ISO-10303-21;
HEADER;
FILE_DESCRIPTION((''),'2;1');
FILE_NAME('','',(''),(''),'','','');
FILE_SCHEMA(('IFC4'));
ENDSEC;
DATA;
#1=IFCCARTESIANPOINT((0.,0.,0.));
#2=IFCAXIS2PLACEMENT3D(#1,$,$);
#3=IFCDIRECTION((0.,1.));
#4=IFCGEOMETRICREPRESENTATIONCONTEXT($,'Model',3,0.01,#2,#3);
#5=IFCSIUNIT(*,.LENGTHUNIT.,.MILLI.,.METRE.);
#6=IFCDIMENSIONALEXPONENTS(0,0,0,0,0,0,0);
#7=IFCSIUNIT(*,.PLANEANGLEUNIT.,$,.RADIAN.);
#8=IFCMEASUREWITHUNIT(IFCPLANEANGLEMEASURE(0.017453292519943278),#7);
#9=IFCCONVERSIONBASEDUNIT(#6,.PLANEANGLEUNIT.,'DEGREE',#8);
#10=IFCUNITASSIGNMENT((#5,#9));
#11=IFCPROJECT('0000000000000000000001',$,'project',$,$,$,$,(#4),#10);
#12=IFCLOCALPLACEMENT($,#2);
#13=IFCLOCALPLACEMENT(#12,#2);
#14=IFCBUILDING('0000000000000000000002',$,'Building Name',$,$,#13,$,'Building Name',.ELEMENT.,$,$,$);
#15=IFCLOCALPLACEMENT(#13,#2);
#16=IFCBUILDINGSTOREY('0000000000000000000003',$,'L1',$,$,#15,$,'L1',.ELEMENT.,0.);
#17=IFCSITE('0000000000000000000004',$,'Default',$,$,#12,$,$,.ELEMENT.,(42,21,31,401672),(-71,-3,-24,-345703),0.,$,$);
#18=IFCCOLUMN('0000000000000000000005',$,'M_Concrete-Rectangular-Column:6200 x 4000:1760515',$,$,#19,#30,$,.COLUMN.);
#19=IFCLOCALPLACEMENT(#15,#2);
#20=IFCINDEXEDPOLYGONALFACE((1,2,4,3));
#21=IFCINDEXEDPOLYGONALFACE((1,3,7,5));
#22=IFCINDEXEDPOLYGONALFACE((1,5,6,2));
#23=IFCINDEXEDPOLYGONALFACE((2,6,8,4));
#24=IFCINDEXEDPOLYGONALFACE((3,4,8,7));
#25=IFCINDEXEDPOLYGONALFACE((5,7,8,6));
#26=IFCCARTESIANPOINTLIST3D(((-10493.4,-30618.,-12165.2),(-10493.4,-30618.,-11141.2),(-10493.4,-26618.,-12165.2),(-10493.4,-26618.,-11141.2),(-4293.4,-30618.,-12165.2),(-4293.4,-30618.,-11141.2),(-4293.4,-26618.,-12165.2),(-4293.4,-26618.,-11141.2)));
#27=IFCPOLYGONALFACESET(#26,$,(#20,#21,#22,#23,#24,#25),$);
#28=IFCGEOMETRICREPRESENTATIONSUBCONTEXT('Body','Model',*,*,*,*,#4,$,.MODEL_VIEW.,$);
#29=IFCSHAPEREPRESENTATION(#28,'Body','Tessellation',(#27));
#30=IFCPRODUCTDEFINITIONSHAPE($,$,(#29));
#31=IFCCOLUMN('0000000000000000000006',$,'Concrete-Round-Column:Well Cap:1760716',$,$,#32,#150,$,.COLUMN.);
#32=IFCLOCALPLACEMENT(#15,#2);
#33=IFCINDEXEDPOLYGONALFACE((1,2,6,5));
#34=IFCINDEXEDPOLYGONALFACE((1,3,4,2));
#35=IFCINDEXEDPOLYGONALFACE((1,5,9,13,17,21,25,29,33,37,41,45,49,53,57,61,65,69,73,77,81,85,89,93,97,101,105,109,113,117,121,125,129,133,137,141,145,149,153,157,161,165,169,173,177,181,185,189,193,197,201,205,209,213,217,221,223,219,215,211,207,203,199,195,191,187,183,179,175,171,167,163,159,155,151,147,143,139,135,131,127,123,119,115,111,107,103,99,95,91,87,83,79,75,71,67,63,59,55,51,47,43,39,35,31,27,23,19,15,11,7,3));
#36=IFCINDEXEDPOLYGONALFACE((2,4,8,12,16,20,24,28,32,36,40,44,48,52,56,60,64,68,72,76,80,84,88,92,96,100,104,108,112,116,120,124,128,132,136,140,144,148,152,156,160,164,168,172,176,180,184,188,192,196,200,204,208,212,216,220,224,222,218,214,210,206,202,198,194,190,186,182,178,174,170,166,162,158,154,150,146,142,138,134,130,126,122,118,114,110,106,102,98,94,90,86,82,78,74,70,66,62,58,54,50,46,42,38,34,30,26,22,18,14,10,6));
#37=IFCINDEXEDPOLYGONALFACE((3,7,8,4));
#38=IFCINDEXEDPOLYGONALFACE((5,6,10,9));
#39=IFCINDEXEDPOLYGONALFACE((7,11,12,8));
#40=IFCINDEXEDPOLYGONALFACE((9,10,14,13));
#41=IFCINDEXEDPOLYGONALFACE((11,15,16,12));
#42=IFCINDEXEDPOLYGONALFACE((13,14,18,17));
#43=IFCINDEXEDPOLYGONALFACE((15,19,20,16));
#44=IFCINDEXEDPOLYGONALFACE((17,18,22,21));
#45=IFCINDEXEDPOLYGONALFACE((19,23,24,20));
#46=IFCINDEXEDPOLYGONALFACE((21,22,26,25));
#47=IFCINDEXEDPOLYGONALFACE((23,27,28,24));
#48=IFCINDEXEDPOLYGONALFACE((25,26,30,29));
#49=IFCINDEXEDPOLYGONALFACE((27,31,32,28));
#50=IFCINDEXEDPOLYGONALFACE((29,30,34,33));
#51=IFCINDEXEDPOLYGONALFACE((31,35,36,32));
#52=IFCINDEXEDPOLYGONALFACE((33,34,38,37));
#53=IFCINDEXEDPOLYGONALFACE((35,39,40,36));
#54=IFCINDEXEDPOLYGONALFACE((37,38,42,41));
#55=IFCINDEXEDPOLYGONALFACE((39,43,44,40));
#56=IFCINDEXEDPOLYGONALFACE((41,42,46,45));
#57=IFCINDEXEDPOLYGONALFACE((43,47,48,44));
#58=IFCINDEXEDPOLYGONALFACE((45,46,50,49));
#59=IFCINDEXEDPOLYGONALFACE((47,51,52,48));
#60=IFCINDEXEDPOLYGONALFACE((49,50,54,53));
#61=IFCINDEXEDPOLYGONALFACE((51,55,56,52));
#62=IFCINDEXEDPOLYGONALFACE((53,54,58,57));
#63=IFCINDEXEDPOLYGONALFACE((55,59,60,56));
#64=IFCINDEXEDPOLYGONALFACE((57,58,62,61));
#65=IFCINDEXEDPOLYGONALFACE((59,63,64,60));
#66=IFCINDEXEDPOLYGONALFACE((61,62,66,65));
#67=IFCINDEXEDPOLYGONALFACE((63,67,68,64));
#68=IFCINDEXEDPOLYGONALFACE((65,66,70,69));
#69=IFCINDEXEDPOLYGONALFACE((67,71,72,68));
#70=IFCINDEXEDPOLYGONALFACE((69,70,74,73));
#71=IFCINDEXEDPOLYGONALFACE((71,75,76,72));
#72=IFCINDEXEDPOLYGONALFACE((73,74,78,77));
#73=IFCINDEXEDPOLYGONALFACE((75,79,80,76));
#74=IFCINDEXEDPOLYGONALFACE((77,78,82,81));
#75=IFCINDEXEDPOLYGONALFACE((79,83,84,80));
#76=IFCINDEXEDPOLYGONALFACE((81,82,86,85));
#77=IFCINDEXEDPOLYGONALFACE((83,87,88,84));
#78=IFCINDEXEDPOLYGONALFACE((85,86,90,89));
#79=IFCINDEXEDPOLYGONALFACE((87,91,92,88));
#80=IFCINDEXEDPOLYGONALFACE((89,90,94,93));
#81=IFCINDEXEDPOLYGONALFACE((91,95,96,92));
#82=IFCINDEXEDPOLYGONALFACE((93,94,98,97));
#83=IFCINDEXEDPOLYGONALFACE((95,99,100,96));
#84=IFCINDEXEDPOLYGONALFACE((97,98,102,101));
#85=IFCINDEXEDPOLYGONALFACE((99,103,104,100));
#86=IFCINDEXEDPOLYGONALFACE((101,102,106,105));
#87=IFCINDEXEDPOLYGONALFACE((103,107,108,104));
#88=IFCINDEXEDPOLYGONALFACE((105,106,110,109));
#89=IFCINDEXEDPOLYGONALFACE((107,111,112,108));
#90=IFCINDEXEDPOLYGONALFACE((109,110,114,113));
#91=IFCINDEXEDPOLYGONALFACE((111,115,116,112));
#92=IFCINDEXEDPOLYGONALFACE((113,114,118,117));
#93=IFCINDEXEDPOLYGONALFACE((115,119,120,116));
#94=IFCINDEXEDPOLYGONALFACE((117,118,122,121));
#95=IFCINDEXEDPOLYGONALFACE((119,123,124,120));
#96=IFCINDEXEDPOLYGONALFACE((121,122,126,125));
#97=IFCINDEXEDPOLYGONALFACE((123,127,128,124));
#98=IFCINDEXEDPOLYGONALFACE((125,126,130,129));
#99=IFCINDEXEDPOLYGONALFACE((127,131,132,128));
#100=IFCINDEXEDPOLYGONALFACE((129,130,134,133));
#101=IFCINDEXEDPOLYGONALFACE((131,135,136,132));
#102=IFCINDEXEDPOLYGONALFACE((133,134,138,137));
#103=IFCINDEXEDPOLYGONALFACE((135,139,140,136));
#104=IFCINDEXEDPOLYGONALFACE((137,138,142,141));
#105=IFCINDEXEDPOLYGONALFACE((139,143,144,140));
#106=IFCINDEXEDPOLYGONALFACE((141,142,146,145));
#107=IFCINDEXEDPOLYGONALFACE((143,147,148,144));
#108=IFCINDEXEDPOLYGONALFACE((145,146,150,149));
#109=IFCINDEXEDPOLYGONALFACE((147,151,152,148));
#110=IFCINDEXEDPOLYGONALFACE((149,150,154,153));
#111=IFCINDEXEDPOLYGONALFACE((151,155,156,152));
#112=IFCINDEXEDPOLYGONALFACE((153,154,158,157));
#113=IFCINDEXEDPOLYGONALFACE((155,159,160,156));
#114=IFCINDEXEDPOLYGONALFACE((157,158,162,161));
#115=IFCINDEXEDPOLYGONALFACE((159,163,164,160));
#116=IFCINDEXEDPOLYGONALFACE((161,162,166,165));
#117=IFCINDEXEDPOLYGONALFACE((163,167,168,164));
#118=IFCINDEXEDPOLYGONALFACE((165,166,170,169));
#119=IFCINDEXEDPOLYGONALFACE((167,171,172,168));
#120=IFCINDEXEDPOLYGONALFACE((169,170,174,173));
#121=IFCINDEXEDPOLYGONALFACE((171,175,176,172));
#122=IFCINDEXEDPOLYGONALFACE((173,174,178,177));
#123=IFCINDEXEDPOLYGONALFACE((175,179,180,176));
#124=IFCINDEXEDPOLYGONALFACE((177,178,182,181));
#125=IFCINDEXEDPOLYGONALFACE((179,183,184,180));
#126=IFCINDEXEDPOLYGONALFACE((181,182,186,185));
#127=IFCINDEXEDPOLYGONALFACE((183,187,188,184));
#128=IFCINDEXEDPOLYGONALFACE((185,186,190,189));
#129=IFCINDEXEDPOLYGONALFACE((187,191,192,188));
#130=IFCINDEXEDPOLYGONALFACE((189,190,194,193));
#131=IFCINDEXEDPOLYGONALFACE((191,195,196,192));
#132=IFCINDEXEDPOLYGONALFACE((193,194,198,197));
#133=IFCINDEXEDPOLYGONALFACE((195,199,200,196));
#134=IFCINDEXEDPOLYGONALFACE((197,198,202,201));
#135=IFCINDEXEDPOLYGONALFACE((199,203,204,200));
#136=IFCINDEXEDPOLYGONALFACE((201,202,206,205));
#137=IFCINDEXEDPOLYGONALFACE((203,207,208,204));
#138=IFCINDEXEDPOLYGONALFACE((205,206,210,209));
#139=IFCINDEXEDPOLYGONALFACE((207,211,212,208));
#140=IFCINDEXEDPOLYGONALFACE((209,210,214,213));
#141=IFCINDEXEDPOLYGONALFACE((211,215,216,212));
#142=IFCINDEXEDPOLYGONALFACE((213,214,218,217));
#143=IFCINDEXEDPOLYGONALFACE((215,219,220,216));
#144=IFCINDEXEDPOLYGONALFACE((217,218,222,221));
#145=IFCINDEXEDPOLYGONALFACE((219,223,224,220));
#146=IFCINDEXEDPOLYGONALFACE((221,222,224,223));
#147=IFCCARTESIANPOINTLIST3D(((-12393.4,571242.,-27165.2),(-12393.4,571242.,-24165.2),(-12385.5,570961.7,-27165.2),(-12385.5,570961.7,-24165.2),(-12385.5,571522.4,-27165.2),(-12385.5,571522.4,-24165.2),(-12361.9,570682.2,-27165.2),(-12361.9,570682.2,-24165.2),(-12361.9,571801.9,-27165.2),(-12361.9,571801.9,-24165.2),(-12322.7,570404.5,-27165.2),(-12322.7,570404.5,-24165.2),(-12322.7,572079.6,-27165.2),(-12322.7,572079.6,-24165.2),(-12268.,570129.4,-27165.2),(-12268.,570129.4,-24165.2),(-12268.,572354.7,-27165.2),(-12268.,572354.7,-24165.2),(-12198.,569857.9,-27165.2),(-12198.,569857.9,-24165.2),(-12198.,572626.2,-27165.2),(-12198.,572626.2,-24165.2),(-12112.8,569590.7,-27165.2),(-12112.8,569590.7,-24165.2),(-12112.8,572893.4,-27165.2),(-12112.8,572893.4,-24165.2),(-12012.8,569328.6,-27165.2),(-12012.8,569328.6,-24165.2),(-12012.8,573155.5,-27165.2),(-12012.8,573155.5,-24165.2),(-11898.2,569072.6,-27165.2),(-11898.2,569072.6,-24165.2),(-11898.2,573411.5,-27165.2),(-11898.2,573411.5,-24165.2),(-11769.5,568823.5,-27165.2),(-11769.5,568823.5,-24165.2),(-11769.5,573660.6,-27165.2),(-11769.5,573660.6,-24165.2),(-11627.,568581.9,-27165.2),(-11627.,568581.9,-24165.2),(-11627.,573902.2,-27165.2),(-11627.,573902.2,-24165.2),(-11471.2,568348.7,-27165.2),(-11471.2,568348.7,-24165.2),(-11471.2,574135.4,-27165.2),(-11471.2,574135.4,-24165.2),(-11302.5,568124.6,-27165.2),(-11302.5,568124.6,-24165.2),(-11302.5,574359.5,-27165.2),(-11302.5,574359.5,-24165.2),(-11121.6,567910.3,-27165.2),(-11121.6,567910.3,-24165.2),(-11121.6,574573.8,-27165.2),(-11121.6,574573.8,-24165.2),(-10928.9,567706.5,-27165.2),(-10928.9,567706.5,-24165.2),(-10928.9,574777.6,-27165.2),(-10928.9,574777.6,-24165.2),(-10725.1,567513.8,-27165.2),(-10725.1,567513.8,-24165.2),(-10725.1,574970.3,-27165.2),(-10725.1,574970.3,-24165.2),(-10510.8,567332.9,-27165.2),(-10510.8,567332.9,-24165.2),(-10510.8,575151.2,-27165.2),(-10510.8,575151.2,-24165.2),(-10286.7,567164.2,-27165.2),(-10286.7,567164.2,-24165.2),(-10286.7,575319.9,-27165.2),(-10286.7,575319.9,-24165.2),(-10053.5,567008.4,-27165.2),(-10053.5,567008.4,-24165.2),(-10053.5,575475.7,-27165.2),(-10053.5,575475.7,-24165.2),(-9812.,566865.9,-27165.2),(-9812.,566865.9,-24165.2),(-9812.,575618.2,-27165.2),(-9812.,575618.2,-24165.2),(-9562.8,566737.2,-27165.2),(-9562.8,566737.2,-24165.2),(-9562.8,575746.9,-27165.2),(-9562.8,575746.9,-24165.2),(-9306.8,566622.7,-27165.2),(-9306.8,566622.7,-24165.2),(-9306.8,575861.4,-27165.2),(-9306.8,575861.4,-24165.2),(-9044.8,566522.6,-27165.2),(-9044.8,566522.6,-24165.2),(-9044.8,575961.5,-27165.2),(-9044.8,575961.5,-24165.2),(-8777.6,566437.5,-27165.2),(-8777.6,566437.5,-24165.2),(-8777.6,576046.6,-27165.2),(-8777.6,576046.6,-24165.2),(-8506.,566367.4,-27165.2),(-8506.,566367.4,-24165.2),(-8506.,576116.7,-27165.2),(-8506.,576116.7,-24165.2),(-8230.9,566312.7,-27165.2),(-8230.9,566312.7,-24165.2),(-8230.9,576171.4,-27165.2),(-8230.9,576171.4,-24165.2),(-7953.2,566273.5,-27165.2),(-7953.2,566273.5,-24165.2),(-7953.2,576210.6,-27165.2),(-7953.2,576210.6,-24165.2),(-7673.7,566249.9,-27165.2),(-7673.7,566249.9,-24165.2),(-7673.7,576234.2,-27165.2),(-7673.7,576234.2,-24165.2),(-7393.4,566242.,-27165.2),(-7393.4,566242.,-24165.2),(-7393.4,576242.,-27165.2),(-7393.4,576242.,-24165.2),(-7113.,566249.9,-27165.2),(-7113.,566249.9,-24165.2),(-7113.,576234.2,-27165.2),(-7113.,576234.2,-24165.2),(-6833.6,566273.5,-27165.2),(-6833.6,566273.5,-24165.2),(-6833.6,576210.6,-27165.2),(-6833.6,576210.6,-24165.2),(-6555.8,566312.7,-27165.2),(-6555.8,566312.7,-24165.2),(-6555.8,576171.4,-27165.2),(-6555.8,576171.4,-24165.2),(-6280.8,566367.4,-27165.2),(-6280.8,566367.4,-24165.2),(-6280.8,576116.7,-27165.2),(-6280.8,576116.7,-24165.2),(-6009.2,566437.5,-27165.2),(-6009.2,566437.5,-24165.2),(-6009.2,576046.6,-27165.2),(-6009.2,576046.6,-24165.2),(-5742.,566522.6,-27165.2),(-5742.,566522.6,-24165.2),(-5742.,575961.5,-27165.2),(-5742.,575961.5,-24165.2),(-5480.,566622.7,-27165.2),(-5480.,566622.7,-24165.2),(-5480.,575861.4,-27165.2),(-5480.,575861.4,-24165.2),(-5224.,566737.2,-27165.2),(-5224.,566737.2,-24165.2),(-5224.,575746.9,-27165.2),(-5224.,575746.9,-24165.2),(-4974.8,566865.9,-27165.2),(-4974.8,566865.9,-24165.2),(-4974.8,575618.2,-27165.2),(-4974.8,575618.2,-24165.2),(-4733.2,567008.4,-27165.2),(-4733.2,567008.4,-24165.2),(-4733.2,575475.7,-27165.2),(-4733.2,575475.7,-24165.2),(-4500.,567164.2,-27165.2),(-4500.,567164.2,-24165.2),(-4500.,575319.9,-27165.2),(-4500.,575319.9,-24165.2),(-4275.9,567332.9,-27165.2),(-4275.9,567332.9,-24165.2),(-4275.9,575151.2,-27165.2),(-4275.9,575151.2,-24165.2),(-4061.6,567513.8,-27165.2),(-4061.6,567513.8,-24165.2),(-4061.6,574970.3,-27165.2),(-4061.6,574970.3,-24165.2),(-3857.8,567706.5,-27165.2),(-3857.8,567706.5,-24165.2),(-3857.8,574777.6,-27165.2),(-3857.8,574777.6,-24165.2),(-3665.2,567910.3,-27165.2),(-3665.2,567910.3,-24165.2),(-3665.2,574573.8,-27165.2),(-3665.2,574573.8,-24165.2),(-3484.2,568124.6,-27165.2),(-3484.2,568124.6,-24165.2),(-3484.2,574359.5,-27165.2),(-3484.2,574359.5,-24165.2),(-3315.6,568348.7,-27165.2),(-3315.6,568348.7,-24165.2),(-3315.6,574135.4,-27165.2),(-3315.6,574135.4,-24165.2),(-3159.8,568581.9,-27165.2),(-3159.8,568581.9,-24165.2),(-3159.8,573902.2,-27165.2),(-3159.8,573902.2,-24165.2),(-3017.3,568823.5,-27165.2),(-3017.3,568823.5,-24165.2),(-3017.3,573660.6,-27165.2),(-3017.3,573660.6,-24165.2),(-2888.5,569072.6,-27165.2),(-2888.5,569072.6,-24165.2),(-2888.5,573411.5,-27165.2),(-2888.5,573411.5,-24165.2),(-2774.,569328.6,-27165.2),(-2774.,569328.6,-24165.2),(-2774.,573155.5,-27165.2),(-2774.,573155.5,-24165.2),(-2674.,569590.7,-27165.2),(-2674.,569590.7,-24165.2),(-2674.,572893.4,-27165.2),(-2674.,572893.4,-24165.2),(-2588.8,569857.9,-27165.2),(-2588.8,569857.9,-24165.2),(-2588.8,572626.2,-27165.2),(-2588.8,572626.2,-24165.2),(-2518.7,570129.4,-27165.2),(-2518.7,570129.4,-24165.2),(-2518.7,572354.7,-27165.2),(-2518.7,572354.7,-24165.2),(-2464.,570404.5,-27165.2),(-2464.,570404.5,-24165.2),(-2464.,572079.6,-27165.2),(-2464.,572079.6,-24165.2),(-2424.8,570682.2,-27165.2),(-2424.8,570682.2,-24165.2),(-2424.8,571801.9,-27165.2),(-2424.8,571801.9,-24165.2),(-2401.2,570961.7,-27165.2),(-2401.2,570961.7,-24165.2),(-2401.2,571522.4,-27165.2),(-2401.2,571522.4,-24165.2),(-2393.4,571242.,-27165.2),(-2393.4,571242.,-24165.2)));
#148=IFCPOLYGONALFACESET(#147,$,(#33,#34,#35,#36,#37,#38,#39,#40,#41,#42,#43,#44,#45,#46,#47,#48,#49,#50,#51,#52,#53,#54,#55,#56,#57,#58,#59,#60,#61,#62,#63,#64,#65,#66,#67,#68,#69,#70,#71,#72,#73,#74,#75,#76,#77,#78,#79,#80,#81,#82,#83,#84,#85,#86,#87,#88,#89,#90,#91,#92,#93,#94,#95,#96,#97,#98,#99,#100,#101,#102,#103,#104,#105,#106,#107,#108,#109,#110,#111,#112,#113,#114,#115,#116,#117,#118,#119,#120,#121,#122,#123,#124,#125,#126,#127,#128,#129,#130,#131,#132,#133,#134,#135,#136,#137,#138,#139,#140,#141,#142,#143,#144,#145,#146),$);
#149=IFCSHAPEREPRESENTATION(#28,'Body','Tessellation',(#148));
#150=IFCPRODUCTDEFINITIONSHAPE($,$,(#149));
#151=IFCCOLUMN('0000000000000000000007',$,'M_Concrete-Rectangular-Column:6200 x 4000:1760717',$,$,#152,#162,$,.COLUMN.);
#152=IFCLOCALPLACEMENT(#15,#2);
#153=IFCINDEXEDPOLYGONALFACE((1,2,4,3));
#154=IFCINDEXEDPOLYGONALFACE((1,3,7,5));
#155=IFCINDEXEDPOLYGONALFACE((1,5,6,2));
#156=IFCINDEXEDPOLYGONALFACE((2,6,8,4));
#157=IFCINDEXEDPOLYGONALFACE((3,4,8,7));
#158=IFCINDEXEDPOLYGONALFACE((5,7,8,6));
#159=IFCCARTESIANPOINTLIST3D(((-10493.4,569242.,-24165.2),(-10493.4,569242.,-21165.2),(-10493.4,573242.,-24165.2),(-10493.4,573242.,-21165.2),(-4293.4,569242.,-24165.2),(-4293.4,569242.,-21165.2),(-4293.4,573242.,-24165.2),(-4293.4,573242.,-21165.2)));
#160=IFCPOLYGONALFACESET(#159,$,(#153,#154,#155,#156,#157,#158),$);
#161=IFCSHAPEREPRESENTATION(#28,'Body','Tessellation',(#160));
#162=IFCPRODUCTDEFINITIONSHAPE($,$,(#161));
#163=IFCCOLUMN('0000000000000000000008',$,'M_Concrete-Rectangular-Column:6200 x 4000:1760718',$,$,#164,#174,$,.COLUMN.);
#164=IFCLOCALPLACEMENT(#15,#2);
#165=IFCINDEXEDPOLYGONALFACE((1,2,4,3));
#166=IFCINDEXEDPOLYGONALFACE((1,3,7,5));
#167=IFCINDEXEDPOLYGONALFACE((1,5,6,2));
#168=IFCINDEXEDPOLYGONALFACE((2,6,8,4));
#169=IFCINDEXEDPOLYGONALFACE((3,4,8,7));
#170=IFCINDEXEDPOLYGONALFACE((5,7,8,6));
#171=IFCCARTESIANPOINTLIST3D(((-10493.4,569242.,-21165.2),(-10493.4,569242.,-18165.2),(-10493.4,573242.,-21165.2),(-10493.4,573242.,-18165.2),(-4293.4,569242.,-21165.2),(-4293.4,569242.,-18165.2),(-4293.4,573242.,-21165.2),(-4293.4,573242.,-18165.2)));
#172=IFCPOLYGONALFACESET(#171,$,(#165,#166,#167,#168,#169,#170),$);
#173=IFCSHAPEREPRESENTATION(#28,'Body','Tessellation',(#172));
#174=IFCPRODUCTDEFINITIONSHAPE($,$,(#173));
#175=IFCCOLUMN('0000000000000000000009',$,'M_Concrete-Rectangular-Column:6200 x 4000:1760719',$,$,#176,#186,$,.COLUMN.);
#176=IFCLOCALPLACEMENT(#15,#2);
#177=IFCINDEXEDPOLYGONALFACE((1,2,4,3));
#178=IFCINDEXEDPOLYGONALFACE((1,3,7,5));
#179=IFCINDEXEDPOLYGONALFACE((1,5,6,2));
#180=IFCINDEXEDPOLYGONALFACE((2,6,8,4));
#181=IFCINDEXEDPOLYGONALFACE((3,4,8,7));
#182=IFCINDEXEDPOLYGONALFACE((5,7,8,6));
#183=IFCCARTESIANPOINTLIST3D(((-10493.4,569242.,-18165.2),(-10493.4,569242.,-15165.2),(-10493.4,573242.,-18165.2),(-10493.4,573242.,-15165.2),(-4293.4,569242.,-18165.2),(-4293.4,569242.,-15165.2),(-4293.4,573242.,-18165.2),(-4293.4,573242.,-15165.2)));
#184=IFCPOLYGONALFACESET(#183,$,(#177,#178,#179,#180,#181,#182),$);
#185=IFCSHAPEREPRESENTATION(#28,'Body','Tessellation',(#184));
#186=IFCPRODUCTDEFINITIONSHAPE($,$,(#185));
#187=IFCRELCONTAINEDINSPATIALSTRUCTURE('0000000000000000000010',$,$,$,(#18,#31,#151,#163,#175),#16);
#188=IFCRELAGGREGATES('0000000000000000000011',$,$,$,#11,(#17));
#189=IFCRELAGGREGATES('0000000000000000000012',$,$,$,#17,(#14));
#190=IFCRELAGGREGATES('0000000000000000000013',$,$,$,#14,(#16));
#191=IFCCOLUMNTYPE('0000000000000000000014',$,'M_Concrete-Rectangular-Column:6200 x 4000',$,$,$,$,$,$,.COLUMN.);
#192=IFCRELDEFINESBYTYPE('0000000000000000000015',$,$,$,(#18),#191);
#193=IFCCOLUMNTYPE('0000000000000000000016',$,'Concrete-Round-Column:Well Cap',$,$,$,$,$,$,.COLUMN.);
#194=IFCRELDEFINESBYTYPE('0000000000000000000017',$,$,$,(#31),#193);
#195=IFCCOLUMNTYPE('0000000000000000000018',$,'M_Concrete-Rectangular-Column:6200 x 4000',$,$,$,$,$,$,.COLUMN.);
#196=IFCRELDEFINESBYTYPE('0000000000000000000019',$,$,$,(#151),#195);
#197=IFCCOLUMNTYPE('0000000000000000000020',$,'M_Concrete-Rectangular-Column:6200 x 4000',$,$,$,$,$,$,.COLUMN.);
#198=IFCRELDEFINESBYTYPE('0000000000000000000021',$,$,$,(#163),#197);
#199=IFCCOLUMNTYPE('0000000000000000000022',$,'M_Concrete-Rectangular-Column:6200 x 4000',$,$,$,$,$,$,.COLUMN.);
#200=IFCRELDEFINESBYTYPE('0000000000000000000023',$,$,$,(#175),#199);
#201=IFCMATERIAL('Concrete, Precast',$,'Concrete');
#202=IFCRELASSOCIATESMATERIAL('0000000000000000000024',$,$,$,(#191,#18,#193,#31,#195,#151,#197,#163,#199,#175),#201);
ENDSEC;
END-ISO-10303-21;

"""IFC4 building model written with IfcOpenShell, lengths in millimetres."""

from ifc_helpers import new_model, entity, si_unit, converted_unit, direction, frame, origin, place, context, subcontext, project, spatial, arc, indexed_curve, outline, extrude, source, transform, mapped, material, type_object, type_shapes, element, save


model = new_model("IFC4")

# Units and contexts
model_context = context("Model", 3, precision=0.01, world=origin(), true_north=direction((0.0, 1.0)))
body_context = subcontext(model_context, "Body", "Model", "MODEL_VIEW")
ifc_project = project(units=[si_unit("LENGTHUNIT", "METRE", prefix="MILLI"), converted_unit("PLANEANGLEUNIT", "DEGREE", entity("IfcPlaneAngleMeasure", 0.017453292519943278), si_unit("PLANEANGLEUNIT", "RADIAN"), dimensions=[0, 0, 0, 0, 0, 0, 0])], contexts=[model_context])

# Site, building, storey
site_placement = place(None, origin())
site = spatial("IfcSite", under=ifc_project, at=site_placement, Name="Default", CompositionType="ELEMENT", RefLatitude=(42, 21, 31, 401672), RefLongitude=(-71, -3, -24, -345703), RefElevation=0.0)
building_placement = place(site_placement, origin())
building = spatial("IfcBuilding", under=site, at=building_placement, Name="Building Name", LongName="Building Name", CompositionType="ELEMENT")
storey_placement = place(building_placement, origin())
storey = spatial("IfcBuildingStorey", under=building, at=storey_placement, Name="L1", LongName="L1", CompositionType="ELEMENT", Elevation=0.0)

# Columns
ifc_material_1 = material(Name="Concrete, Precast", Category="Concrete")
column_type_1 = type_object("IfcColumnType", Name="M_Concrete-Rectangular-Column:6200 x 4000", PredefinedType="COLUMN", material=ifc_material_1)
shared_shape_1 = source(origin(), body_context, "Body", "SweptSolid", [
    extrude(outline(indexed_curve([(-2000.0, -3100.0), (2000.0, -3100.0), (2000.0, 3100.0), (-2000.0, 3100.0), (-2000.0, -3100.0)], self_intersect=False)), frame((-7393.4, -28618.0, -12165.2), z_axis=(0.0, 0.0, 1.0), x_axis=(0.0, -1.0, 0.0)), (0.0, 0.0, 1.0), 1024.0),
])
type_shapes(column_type_1, [shared_shape_1])
column_1_placement = place(storey_placement, origin())
element("IfcColumn", 1, at=column_1_placement, inside=storey, type_object=column_type_1, material=ifc_material_1, Name="M_Concrete-Rectangular-Column:6200 x 4000:1760515", PredefinedType="COLUMN", context=body_context, shape_type="MappedRepresentation", body=[
    mapped(shared_shape_1, transform((0.0, 0.0, 0.0), scale=1.0)),
])
column_type_2 = type_object("IfcColumnType", Name="Concrete-Round-Column:Well Cap", PredefinedType="COLUMN", material=ifc_material_1)
shared_shape_2 = source(origin(), body_context, "Body", "SweptSolid", [
    extrude(outline(indexed_curve([(5000.0, 0.0), (0.0, 5000.0), (-5000.0, 0.0), (0.0, -5000.0)], segments=[arc(1, 2, 3), arc(3, 4, 1)], self_intersect=False)), frame((-7393.4, 571242.0, -27165.2)), (0.0, 0.0, 1.0), 3000.0),
])
type_shapes(column_type_2, [shared_shape_2])
column_2_placement = place(storey_placement, origin())
element("IfcColumn", 2, at=column_2_placement, inside=storey, type_object=column_type_2, material=ifc_material_1, Name="Concrete-Round-Column:Well Cap:1760716", PredefinedType="COLUMN", context=body_context, shape_type="MappedRepresentation", body=[
    mapped(shared_shape_2, transform((0.0, 0.0, 0.0), scale=1.0)),
])
column_type_3 = type_object("IfcColumnType", Name="M_Concrete-Rectangular-Column:6200 x 4000", PredefinedType="COLUMN", material=ifc_material_1)
shared_shape_3 = source(origin(), body_context, "Body", "SweptSolid", [
    extrude(outline(indexed_curve([(-2000.0, -3100.0), (2000.0, -3100.0), (2000.0, 3100.0), (-2000.0, 3100.0), (-2000.0, -3100.0)], self_intersect=False)), frame((-7393.4, 571242.0, -24165.2), z_axis=(0.0, 0.0, 1.0), x_axis=(0.0, -1.0, 0.0)), (0.0, 0.0, 1.0), 3000.0),
])
type_shapes(column_type_3, [shared_shape_3])
column_3_placement = place(storey_placement, origin())
element("IfcColumn", 3, at=column_3_placement, inside=storey, type_object=column_type_3, material=ifc_material_1, Name="M_Concrete-Rectangular-Column:6200 x 4000:1760717", PredefinedType="COLUMN", context=body_context, shape_type="MappedRepresentation", body=[
    mapped(shared_shape_3, transform((0.0, 0.0, 0.0), scale=1.0)),
])
column_type_4 = type_object("IfcColumnType", Name="M_Concrete-Rectangular-Column:6200 x 4000", PredefinedType="COLUMN", material=ifc_material_1)
shared_shape_4 = source(origin(), body_context, "Body", "SweptSolid", [
    extrude(outline(indexed_curve([(-2000.0, -3100.0), (2000.0, -3100.0), (2000.0, 3100.0), (-2000.0, 3100.0), (-2000.0, -3100.0)], self_intersect=False)), frame((-7393.4, 571242.0, -21165.2), z_axis=(0.0, 0.0, 1.0), x_axis=(0.0, -1.0, 0.0)), (0.0, 0.0, 1.0), 3000.0),
])
type_shapes(column_type_4, [shared_shape_4])
column_4_placement = place(storey_placement, origin())
element("IfcColumn", 4, at=column_4_placement, inside=storey, type_object=column_type_4, material=ifc_material_1, Name="M_Concrete-Rectangular-Column:6200 x 4000:1760718", PredefinedType="COLUMN", context=body_context, shape_type="MappedRepresentation", body=[
    mapped(shared_shape_4, transform((0.0, 0.0, 0.0), scale=1.0)),
])
column_type_5 = type_object("IfcColumnType", Name="M_Concrete-Rectangular-Column:6200 x 4000", PredefinedType="COLUMN", material=ifc_material_1)
shared_shape_5 = source(origin(), body_context, "Body", "SweptSolid", [
    extrude(outline(indexed_curve([(-2000.0, -3100.0), (2000.0, -3100.0), (2000.0, 3100.0), (-2000.0, 3100.0), (-2000.0, -3100.0)], self_intersect=False)), frame((-7393.4, 571242.0, -18165.2), z_axis=(0.0, 0.0, 1.0), x_axis=(0.0, -1.0, 0.0)), (0.0, 0.0, 1.0), 3000.0),
])
type_shapes(column_type_5, [shared_shape_5])
column_5_placement = place(storey_placement, origin())
element("IfcColumn", 5, at=column_5_placement, inside=storey, type_object=column_type_5, material=ifc_material_1, Name="M_Concrete-Rectangular-Column:6200 x 4000:1760719", PredefinedType="COLUMN", context=body_context, shape_type="MappedRepresentation", body=[
    mapped(shared_shape_5, transform((0.0, 0.0, 0.0), scale=1.0)),
])

save(model, "model.ifc")
